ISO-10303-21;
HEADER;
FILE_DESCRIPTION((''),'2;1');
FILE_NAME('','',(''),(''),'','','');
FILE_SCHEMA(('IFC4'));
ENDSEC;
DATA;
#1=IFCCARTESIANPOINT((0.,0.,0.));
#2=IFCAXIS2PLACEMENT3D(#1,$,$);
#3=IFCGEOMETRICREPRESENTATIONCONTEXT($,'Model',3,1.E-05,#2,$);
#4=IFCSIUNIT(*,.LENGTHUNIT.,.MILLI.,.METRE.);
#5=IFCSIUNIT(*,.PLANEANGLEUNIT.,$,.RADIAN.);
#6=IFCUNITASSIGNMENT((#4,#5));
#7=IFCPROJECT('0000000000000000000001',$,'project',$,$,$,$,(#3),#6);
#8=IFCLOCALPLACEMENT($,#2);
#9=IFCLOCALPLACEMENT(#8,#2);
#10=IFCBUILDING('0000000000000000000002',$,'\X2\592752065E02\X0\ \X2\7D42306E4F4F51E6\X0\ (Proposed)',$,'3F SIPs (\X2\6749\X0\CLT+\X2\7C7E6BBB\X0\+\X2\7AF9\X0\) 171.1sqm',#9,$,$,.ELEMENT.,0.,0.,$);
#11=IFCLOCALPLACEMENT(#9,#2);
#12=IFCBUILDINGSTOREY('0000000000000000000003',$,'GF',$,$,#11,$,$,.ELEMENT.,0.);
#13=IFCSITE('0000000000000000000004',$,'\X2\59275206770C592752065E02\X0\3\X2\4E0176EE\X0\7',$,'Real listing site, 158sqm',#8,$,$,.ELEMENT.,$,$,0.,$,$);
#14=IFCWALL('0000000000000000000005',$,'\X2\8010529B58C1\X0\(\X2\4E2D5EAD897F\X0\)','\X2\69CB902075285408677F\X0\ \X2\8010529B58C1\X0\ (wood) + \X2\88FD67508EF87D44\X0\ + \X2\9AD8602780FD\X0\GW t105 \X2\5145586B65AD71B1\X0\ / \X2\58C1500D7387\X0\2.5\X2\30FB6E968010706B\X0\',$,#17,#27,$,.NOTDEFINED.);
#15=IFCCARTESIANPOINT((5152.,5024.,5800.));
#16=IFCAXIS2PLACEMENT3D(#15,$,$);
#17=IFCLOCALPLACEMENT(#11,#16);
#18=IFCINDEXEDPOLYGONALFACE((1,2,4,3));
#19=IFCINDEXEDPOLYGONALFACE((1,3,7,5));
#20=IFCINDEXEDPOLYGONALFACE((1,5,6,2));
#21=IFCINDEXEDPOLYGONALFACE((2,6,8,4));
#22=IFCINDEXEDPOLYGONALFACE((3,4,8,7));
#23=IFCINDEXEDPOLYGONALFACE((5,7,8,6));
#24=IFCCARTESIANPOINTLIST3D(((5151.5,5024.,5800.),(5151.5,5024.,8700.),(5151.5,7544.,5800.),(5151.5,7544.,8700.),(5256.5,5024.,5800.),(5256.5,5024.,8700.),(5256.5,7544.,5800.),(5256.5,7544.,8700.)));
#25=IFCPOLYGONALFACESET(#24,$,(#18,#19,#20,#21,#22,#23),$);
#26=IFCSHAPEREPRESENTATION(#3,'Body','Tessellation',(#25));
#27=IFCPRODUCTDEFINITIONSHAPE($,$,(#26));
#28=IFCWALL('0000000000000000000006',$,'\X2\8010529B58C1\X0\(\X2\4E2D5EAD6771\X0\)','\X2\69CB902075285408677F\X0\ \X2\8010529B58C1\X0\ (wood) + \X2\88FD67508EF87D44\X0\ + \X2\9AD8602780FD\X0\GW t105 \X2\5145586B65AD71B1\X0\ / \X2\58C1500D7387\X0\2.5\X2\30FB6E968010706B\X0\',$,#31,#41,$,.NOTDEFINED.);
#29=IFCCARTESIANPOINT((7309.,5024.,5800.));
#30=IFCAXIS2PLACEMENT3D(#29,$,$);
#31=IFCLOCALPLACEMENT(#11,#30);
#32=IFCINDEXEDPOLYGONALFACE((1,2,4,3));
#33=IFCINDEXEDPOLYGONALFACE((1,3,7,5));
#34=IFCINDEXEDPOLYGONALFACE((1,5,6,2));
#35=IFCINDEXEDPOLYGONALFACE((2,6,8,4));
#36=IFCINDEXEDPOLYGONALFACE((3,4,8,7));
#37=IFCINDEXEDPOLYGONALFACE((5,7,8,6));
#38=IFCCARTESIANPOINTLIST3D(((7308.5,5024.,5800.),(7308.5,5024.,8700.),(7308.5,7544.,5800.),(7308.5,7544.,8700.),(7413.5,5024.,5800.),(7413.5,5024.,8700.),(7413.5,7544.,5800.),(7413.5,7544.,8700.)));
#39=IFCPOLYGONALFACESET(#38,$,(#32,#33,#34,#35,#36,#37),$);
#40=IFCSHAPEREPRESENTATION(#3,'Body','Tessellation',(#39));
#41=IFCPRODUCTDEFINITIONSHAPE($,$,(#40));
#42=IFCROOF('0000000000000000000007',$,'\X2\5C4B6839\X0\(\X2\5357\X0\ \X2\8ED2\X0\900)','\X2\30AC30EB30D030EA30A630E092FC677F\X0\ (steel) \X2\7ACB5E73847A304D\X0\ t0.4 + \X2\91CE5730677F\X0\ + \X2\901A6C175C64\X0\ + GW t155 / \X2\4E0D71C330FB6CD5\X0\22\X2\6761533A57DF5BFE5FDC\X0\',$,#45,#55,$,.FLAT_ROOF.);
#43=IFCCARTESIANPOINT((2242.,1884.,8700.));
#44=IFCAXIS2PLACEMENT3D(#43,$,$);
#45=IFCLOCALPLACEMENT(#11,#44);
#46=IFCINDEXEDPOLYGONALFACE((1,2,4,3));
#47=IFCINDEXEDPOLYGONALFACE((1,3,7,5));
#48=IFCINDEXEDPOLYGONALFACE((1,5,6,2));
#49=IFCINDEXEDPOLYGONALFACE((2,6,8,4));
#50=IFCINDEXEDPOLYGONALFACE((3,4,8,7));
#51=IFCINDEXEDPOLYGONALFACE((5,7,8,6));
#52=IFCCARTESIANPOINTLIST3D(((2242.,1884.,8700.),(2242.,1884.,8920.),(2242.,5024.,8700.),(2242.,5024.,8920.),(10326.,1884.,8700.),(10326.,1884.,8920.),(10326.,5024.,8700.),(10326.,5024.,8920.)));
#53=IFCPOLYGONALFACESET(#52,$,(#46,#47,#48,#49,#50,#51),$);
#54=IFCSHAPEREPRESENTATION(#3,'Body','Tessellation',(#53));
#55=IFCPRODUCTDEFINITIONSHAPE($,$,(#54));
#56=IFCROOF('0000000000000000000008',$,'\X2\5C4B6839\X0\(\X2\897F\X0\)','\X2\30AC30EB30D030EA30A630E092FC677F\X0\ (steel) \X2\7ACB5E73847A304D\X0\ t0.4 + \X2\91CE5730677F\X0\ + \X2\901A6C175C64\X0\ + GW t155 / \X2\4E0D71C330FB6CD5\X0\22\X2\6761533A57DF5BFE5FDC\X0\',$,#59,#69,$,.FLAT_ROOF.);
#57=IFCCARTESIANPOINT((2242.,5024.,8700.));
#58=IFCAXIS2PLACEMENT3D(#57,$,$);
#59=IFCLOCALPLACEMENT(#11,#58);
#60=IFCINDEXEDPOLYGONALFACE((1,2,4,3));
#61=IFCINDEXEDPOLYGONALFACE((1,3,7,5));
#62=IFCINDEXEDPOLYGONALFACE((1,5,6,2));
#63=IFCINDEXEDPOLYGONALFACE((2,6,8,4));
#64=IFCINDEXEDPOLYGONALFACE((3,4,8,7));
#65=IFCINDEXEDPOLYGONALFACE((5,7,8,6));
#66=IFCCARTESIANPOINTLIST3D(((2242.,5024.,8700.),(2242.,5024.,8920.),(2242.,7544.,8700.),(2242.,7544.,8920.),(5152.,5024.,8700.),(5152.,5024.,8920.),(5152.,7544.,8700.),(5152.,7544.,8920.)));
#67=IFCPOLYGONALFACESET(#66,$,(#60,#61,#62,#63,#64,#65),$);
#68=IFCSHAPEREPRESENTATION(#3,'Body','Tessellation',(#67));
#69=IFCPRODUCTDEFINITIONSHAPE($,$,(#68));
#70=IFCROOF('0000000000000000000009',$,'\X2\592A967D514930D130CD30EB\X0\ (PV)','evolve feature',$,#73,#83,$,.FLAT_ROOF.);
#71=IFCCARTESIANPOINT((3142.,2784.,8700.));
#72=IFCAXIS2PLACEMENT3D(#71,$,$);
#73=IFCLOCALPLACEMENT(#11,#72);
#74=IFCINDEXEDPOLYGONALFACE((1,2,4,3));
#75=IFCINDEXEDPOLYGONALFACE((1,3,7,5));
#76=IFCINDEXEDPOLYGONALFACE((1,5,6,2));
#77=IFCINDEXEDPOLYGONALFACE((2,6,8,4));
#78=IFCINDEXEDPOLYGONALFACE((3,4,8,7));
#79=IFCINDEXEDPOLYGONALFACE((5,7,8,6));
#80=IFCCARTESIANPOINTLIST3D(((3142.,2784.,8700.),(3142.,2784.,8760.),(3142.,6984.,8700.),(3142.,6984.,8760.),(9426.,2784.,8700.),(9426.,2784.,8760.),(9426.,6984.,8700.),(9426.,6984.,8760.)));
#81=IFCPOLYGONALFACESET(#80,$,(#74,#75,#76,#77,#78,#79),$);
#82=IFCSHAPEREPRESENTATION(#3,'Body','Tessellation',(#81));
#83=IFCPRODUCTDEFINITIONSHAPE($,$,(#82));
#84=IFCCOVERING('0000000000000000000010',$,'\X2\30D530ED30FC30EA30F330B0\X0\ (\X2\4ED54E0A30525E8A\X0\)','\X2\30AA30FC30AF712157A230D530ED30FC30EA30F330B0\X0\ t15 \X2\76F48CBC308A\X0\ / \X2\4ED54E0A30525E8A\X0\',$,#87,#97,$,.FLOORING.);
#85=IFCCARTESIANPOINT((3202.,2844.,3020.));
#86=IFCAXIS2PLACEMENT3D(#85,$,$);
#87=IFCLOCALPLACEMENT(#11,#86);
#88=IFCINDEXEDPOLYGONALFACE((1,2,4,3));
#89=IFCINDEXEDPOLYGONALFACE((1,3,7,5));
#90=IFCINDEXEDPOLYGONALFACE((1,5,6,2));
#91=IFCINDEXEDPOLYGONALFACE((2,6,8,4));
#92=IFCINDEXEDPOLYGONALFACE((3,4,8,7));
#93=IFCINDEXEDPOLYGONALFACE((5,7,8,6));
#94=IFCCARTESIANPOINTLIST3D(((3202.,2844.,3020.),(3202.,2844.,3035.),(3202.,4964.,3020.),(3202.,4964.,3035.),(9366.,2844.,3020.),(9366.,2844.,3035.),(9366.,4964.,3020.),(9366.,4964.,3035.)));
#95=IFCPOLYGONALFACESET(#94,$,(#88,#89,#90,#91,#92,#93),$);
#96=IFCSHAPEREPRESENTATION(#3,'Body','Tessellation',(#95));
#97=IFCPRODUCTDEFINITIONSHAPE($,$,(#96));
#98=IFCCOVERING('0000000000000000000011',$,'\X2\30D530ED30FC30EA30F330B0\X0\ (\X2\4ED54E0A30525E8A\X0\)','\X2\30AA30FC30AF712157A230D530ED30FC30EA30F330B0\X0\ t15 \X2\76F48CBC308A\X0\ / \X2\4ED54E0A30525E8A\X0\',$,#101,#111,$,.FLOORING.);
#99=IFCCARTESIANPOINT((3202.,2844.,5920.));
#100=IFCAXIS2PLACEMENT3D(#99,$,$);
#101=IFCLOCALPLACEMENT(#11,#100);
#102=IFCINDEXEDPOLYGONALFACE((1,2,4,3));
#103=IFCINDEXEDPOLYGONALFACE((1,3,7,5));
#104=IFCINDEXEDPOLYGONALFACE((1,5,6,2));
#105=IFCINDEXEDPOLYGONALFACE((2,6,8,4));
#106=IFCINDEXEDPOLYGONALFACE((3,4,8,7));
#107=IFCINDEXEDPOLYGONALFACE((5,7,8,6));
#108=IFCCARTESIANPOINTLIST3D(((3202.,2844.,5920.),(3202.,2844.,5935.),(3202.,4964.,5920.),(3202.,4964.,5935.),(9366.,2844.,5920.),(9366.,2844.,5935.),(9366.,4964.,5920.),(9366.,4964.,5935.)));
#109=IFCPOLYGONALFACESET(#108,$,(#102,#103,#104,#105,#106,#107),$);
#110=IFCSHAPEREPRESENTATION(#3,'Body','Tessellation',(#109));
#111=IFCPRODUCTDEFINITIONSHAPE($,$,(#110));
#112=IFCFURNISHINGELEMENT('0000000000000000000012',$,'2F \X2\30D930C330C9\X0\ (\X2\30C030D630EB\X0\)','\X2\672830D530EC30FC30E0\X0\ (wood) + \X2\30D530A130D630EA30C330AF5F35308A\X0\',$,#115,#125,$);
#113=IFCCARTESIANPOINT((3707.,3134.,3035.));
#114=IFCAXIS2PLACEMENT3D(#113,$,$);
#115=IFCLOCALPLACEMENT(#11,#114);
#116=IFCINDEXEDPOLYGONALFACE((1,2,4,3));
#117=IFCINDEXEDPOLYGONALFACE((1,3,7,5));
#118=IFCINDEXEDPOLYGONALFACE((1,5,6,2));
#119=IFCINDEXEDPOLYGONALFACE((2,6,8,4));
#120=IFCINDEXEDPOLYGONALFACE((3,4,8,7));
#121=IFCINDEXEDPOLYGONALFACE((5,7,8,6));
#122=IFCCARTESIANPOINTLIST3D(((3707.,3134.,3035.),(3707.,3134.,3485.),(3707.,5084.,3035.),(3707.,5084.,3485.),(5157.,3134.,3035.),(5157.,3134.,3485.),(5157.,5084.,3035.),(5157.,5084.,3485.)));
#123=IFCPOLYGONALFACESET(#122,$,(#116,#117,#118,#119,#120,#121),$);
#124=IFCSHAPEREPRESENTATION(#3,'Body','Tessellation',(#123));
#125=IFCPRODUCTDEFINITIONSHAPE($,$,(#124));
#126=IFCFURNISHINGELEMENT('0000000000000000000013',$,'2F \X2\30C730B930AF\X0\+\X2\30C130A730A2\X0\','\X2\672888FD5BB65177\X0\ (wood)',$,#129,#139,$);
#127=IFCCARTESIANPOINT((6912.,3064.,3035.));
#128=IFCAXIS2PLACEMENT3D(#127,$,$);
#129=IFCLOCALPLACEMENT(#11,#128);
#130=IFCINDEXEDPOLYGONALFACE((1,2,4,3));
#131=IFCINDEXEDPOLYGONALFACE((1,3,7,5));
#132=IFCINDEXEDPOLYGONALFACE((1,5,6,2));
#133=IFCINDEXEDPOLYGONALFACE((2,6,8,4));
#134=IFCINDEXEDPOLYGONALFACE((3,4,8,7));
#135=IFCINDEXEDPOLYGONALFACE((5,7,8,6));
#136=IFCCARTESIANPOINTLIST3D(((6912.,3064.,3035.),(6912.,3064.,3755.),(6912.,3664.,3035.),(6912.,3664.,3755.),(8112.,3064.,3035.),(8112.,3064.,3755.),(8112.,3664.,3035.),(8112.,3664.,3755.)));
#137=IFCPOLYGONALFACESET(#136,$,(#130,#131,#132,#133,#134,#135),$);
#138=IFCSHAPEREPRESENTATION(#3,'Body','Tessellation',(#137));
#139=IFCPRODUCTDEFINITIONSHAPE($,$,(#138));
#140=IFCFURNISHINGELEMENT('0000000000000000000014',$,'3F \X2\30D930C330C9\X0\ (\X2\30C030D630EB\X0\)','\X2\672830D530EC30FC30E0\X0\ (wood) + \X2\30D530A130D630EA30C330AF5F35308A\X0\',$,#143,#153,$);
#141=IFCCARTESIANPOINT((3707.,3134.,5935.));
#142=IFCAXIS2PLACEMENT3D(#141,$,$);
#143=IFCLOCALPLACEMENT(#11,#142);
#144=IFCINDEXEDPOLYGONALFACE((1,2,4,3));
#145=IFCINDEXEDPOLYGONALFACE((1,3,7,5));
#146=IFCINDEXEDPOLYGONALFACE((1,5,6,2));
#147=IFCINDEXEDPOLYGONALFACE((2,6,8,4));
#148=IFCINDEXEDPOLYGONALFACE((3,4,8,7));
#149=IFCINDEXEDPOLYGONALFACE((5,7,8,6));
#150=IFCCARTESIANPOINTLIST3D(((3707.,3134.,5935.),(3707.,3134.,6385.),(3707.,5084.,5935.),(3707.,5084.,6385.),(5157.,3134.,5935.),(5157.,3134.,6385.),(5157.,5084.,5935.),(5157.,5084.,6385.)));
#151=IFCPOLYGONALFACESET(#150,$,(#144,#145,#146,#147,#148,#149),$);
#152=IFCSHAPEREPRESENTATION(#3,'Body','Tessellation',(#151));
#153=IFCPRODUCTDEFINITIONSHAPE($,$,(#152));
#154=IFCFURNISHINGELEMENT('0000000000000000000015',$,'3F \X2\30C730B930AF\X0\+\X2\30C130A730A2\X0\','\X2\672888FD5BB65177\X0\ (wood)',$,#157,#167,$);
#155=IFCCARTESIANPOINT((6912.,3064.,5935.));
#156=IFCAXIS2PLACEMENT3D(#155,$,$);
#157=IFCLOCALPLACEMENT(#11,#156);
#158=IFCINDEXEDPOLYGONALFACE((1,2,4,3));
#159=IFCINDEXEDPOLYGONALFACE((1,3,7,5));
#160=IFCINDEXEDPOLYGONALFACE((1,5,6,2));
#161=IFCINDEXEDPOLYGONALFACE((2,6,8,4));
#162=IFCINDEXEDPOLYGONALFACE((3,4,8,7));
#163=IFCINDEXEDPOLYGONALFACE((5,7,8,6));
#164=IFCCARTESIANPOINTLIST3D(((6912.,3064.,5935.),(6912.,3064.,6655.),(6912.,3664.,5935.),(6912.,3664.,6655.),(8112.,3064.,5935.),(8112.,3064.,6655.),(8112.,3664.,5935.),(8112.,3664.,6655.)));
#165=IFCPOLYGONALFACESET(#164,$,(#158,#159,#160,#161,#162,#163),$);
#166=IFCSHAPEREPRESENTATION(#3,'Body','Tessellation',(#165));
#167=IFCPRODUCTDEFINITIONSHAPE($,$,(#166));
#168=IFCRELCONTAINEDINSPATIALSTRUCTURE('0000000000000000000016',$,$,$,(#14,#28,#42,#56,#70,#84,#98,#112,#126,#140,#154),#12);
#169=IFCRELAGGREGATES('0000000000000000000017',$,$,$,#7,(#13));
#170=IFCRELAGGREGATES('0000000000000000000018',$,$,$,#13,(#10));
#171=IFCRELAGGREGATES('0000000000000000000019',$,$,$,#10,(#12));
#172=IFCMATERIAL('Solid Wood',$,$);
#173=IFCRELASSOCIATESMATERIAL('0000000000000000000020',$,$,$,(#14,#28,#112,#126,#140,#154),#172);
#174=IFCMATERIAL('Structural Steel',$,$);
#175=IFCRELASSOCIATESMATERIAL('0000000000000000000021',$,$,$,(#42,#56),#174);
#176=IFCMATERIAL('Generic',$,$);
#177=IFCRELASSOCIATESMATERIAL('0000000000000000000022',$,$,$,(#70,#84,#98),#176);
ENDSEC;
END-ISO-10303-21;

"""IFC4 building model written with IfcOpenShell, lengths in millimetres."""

from ifc_helpers import new_model, si_unit, frame, frame_2d, origin, place, context, project, spatial, rectangle, extrude, material, element, save


model = new_model("IFC4")

# Units and contexts
model_context = context("Model", 3, precision=1e-05, world=origin())
ifc_project = project(units=[si_unit("LENGTHUNIT", "METRE", prefix="MILLI"), si_unit("PLANEANGLEUNIT", "RADIAN")], contexts=[model_context])

# Site, building, storey
site_placement = place(None, origin())
site = spatial("IfcSite", under=ifc_project, at=site_placement, Name="大分県大分市3丁目7", ObjectType="Real listing site, 158sqm", CompositionType="ELEMENT", RefElevation=0.0)
building_placement = place(site_placement, origin())
building = spatial("IfcBuilding", under=site, at=building_placement, Name="大分市 終の住処 (Proposed)", ObjectType="3F SIPs (杉CLT+籾殻+竹) 171.1sqm", CompositionType="ELEMENT", ElevationOfRefHeight=0.0, ElevationOfTerrain=0.0)
storey_placement = place(building_placement, origin())
storey = spatial("IfcBuildingStorey", under=building, at=storey_placement, Name="GF", CompositionType="ELEMENT", Elevation=0.0)

# Shared definitions
ifc_material_1 = material(Name="Solid Wood")

# Walls
wall_1_placement = place(storey_placement, frame((5152.0, 5024.0, 5800.0)))
element("IfcWall", 1, at=wall_1_placement, inside=storey, material=ifc_material_1, Name="耐力壁(中庭西)", Description="構造用合板 耐力壁 (wood) + 製材軸組 + 高性能GW t105 充填断熱 / 壁倍率2.5・準耐火", PredefinedType="NOTDEFINED", context=model_context, shape_type="SweptSolid", body=[
    extrude(rectangle(XDim=105.0, YDim=2520.0, at=frame_2d((52.0, 1260.0))), frame((5152.0, 5024.0, 5800.0)), (0.0, 0.0, 1.0), 2900.0),
])
wall_2_placement = place(storey_placement, frame((7309.0, 5024.0, 5800.0)))
element("IfcWall", 2, at=wall_2_placement, inside=storey, material=ifc_material_1, Name="耐力壁(中庭東)", Description="構造用合板 耐力壁 (wood) + 製材軸組 + 高性能GW t105 充填断熱 / 壁倍率2.5・準耐火", PredefinedType="NOTDEFINED", context=model_context, shape_type="SweptSolid", body=[
    extrude(rectangle(XDim=105.0, YDim=2520.0, at=frame_2d((52.0, 1260.0))), frame((7309.0, 5024.0, 5800.0)), (0.0, 0.0, 1.0), 2900.0),
])

# Roofs
ifc_material_2 = material(Name="Structural Steel")
roof_1_placement = place(storey_placement, frame((2242.0, 1884.0, 8700.0)))
element("IfcRoof", 3, at=roof_1_placement, inside=storey, material=ifc_material_2, Name="屋根(南 軒900)", Description="ガルバリウム鋼板 (steel) 立平葺き t0.4 + 野地板 + 通気層 + GW t155 / 不燃・法22条区域対応", PredefinedType="FLAT_ROOF", context=model_context, shape_type="SweptSolid", body=[
    extrude(rectangle(XDim=8084.0, YDim=3140.0, at=frame_2d((4042.0, 1570.0))), frame((2242.0, 1884.0, 8700.0)), (0.0, 0.0, 1.0), 220.0),
])
roof_2_placement = place(storey_placement, frame((2242.0, 5024.0, 8700.0)))
element("IfcRoof", 4, at=roof_2_placement, inside=storey, material=ifc_material_2, Name="屋根(西)", Description="ガルバリウム鋼板 (steel) 立平葺き t0.4 + 野地板 + 通気層 + GW t155 / 不燃・法22条区域対応", PredefinedType="FLAT_ROOF", context=model_context, shape_type="SweptSolid", body=[
    extrude(rectangle(XDim=2910.0, YDim=2520.0, at=frame_2d((1455.0, 1260.0))), frame((2242.0, 5024.0, 8700.0)), (0.0, 0.0, 1.0), 220.0),
])
ifc_material_3 = material(Name="Generic")
roof_3_placement = place(storey_placement, frame((3142.0, 2784.0, 8700.0)))
element("IfcRoof", 5, at=roof_3_placement, inside=storey, material=ifc_material_3, Name="太陽光パネル (PV)", Description="evolve feature", PredefinedType="FLAT_ROOF", context=model_context, shape_type="SweptSolid", body=[
    extrude(rectangle(XDim=6284.0, YDim=4200.0, at=frame_2d((3142.0, 2100.0))), frame((3142.0, 2784.0, 8700.0)), (0.0, 0.0, 1.0), 60.0),
])

# Coverings
covering_1_placement = place(storey_placement, frame((3202.0, 2844.0, 3020.0)))
element("IfcCovering", 6, at=covering_1_placement, inside=storey, material=ifc_material_3, Name="フローリング (仕上げ床)", Description="オーク無垢フローリング t15 直貼り / 仕上げ床", PredefinedType="FLOORING", context=model_context, shape_type="SweptSolid", body=[
    extrude(rectangle(XDim=6164.0, YDim=2120.0, at=frame_2d((3082.0, 1060.0))), frame((3202.0, 2844.0, 3020.0)), (0.0, 0.0, 1.0), 15.0),
])
covering_2_placement = place(storey_placement, frame((3202.0, 2844.0, 5920.0)))
element("IfcCovering", 7, at=covering_2_placement, inside=storey, material=ifc_material_3, Name="フローリング (仕上げ床)", Description="オーク無垢フローリング t15 直貼り / 仕上げ床", PredefinedType="FLOORING", context=model_context, shape_type="SweptSolid", body=[
    extrude(rectangle(XDim=6164.0, YDim=2120.0, at=frame_2d((3082.0, 1060.0))), frame((3202.0, 2844.0, 5920.0)), (0.0, 0.0, 1.0), 15.0),
])

# Furnishing elements
furnishing_1_placement = place(storey_placement, frame((3707.0, 3134.0, 3035.0)))
element("IfcFurnishingElement", 8, at=furnishing_1_placement, inside=storey, material=ifc_material_1, Name="2F ベッド (ダブル)", Description="木フレーム (wood) + ファブリック張り", context=model_context, shape_type="SweptSolid", body=[
    extrude(rectangle(XDim=1450.0, YDim=1950.0, at=frame_2d((725.0, 975.0))), frame((3707.0, 3134.0, 3035.0)), (0.0, 0.0, 1.0), 450.0),
])
furnishing_2_placement = place(storey_placement, frame((6912.0, 3064.0, 3035.0)))
element("IfcFurnishingElement", 9, at=furnishing_2_placement, inside=storey, material=ifc_material_1, Name="2F デスク+チェア", Description="木製家具 (wood)", context=model_context, shape_type="SweptSolid", body=[
    extrude(rectangle(XDim=1200.0, YDim=600.0, at=frame_2d((600.0, 300.0))), frame((6912.0, 3064.0, 3035.0)), (0.0, 0.0, 1.0), 720.0),
])
furnishing_3_placement = place(storey_placement, frame((3707.0, 3134.0, 5935.0)))
element("IfcFurnishingElement", 10, at=furnishing_3_placement, inside=storey, material=ifc_material_1, Name="3F ベッド (ダブル)", Description="木フレーム (wood) + ファブリック張り", context=model_context, shape_type="SweptSolid", body=[
    extrude(rectangle(XDim=1450.0, YDim=1950.0, at=frame_2d((725.0, 975.0))), frame((3707.0, 3134.0, 5935.0)), (0.0, 0.0, 1.0), 450.0),
])
furnishing_4_placement = place(storey_placement, frame((6912.0, 3064.0, 5935.0)))
element("IfcFurnishingElement", 11, at=furnishing_4_placement, inside=storey, material=ifc_material_1, Name="3F デスク+チェア", Description="木製家具 (wood)", context=model_context, shape_type="SweptSolid", body=[
    extrude(rectangle(XDim=1200.0, YDim=600.0, at=frame_2d((600.0, 300.0))), frame((6912.0, 3064.0, 5935.0)), (0.0, 0.0, 1.0), 720.0),
])

save(model, "model.ifc")
